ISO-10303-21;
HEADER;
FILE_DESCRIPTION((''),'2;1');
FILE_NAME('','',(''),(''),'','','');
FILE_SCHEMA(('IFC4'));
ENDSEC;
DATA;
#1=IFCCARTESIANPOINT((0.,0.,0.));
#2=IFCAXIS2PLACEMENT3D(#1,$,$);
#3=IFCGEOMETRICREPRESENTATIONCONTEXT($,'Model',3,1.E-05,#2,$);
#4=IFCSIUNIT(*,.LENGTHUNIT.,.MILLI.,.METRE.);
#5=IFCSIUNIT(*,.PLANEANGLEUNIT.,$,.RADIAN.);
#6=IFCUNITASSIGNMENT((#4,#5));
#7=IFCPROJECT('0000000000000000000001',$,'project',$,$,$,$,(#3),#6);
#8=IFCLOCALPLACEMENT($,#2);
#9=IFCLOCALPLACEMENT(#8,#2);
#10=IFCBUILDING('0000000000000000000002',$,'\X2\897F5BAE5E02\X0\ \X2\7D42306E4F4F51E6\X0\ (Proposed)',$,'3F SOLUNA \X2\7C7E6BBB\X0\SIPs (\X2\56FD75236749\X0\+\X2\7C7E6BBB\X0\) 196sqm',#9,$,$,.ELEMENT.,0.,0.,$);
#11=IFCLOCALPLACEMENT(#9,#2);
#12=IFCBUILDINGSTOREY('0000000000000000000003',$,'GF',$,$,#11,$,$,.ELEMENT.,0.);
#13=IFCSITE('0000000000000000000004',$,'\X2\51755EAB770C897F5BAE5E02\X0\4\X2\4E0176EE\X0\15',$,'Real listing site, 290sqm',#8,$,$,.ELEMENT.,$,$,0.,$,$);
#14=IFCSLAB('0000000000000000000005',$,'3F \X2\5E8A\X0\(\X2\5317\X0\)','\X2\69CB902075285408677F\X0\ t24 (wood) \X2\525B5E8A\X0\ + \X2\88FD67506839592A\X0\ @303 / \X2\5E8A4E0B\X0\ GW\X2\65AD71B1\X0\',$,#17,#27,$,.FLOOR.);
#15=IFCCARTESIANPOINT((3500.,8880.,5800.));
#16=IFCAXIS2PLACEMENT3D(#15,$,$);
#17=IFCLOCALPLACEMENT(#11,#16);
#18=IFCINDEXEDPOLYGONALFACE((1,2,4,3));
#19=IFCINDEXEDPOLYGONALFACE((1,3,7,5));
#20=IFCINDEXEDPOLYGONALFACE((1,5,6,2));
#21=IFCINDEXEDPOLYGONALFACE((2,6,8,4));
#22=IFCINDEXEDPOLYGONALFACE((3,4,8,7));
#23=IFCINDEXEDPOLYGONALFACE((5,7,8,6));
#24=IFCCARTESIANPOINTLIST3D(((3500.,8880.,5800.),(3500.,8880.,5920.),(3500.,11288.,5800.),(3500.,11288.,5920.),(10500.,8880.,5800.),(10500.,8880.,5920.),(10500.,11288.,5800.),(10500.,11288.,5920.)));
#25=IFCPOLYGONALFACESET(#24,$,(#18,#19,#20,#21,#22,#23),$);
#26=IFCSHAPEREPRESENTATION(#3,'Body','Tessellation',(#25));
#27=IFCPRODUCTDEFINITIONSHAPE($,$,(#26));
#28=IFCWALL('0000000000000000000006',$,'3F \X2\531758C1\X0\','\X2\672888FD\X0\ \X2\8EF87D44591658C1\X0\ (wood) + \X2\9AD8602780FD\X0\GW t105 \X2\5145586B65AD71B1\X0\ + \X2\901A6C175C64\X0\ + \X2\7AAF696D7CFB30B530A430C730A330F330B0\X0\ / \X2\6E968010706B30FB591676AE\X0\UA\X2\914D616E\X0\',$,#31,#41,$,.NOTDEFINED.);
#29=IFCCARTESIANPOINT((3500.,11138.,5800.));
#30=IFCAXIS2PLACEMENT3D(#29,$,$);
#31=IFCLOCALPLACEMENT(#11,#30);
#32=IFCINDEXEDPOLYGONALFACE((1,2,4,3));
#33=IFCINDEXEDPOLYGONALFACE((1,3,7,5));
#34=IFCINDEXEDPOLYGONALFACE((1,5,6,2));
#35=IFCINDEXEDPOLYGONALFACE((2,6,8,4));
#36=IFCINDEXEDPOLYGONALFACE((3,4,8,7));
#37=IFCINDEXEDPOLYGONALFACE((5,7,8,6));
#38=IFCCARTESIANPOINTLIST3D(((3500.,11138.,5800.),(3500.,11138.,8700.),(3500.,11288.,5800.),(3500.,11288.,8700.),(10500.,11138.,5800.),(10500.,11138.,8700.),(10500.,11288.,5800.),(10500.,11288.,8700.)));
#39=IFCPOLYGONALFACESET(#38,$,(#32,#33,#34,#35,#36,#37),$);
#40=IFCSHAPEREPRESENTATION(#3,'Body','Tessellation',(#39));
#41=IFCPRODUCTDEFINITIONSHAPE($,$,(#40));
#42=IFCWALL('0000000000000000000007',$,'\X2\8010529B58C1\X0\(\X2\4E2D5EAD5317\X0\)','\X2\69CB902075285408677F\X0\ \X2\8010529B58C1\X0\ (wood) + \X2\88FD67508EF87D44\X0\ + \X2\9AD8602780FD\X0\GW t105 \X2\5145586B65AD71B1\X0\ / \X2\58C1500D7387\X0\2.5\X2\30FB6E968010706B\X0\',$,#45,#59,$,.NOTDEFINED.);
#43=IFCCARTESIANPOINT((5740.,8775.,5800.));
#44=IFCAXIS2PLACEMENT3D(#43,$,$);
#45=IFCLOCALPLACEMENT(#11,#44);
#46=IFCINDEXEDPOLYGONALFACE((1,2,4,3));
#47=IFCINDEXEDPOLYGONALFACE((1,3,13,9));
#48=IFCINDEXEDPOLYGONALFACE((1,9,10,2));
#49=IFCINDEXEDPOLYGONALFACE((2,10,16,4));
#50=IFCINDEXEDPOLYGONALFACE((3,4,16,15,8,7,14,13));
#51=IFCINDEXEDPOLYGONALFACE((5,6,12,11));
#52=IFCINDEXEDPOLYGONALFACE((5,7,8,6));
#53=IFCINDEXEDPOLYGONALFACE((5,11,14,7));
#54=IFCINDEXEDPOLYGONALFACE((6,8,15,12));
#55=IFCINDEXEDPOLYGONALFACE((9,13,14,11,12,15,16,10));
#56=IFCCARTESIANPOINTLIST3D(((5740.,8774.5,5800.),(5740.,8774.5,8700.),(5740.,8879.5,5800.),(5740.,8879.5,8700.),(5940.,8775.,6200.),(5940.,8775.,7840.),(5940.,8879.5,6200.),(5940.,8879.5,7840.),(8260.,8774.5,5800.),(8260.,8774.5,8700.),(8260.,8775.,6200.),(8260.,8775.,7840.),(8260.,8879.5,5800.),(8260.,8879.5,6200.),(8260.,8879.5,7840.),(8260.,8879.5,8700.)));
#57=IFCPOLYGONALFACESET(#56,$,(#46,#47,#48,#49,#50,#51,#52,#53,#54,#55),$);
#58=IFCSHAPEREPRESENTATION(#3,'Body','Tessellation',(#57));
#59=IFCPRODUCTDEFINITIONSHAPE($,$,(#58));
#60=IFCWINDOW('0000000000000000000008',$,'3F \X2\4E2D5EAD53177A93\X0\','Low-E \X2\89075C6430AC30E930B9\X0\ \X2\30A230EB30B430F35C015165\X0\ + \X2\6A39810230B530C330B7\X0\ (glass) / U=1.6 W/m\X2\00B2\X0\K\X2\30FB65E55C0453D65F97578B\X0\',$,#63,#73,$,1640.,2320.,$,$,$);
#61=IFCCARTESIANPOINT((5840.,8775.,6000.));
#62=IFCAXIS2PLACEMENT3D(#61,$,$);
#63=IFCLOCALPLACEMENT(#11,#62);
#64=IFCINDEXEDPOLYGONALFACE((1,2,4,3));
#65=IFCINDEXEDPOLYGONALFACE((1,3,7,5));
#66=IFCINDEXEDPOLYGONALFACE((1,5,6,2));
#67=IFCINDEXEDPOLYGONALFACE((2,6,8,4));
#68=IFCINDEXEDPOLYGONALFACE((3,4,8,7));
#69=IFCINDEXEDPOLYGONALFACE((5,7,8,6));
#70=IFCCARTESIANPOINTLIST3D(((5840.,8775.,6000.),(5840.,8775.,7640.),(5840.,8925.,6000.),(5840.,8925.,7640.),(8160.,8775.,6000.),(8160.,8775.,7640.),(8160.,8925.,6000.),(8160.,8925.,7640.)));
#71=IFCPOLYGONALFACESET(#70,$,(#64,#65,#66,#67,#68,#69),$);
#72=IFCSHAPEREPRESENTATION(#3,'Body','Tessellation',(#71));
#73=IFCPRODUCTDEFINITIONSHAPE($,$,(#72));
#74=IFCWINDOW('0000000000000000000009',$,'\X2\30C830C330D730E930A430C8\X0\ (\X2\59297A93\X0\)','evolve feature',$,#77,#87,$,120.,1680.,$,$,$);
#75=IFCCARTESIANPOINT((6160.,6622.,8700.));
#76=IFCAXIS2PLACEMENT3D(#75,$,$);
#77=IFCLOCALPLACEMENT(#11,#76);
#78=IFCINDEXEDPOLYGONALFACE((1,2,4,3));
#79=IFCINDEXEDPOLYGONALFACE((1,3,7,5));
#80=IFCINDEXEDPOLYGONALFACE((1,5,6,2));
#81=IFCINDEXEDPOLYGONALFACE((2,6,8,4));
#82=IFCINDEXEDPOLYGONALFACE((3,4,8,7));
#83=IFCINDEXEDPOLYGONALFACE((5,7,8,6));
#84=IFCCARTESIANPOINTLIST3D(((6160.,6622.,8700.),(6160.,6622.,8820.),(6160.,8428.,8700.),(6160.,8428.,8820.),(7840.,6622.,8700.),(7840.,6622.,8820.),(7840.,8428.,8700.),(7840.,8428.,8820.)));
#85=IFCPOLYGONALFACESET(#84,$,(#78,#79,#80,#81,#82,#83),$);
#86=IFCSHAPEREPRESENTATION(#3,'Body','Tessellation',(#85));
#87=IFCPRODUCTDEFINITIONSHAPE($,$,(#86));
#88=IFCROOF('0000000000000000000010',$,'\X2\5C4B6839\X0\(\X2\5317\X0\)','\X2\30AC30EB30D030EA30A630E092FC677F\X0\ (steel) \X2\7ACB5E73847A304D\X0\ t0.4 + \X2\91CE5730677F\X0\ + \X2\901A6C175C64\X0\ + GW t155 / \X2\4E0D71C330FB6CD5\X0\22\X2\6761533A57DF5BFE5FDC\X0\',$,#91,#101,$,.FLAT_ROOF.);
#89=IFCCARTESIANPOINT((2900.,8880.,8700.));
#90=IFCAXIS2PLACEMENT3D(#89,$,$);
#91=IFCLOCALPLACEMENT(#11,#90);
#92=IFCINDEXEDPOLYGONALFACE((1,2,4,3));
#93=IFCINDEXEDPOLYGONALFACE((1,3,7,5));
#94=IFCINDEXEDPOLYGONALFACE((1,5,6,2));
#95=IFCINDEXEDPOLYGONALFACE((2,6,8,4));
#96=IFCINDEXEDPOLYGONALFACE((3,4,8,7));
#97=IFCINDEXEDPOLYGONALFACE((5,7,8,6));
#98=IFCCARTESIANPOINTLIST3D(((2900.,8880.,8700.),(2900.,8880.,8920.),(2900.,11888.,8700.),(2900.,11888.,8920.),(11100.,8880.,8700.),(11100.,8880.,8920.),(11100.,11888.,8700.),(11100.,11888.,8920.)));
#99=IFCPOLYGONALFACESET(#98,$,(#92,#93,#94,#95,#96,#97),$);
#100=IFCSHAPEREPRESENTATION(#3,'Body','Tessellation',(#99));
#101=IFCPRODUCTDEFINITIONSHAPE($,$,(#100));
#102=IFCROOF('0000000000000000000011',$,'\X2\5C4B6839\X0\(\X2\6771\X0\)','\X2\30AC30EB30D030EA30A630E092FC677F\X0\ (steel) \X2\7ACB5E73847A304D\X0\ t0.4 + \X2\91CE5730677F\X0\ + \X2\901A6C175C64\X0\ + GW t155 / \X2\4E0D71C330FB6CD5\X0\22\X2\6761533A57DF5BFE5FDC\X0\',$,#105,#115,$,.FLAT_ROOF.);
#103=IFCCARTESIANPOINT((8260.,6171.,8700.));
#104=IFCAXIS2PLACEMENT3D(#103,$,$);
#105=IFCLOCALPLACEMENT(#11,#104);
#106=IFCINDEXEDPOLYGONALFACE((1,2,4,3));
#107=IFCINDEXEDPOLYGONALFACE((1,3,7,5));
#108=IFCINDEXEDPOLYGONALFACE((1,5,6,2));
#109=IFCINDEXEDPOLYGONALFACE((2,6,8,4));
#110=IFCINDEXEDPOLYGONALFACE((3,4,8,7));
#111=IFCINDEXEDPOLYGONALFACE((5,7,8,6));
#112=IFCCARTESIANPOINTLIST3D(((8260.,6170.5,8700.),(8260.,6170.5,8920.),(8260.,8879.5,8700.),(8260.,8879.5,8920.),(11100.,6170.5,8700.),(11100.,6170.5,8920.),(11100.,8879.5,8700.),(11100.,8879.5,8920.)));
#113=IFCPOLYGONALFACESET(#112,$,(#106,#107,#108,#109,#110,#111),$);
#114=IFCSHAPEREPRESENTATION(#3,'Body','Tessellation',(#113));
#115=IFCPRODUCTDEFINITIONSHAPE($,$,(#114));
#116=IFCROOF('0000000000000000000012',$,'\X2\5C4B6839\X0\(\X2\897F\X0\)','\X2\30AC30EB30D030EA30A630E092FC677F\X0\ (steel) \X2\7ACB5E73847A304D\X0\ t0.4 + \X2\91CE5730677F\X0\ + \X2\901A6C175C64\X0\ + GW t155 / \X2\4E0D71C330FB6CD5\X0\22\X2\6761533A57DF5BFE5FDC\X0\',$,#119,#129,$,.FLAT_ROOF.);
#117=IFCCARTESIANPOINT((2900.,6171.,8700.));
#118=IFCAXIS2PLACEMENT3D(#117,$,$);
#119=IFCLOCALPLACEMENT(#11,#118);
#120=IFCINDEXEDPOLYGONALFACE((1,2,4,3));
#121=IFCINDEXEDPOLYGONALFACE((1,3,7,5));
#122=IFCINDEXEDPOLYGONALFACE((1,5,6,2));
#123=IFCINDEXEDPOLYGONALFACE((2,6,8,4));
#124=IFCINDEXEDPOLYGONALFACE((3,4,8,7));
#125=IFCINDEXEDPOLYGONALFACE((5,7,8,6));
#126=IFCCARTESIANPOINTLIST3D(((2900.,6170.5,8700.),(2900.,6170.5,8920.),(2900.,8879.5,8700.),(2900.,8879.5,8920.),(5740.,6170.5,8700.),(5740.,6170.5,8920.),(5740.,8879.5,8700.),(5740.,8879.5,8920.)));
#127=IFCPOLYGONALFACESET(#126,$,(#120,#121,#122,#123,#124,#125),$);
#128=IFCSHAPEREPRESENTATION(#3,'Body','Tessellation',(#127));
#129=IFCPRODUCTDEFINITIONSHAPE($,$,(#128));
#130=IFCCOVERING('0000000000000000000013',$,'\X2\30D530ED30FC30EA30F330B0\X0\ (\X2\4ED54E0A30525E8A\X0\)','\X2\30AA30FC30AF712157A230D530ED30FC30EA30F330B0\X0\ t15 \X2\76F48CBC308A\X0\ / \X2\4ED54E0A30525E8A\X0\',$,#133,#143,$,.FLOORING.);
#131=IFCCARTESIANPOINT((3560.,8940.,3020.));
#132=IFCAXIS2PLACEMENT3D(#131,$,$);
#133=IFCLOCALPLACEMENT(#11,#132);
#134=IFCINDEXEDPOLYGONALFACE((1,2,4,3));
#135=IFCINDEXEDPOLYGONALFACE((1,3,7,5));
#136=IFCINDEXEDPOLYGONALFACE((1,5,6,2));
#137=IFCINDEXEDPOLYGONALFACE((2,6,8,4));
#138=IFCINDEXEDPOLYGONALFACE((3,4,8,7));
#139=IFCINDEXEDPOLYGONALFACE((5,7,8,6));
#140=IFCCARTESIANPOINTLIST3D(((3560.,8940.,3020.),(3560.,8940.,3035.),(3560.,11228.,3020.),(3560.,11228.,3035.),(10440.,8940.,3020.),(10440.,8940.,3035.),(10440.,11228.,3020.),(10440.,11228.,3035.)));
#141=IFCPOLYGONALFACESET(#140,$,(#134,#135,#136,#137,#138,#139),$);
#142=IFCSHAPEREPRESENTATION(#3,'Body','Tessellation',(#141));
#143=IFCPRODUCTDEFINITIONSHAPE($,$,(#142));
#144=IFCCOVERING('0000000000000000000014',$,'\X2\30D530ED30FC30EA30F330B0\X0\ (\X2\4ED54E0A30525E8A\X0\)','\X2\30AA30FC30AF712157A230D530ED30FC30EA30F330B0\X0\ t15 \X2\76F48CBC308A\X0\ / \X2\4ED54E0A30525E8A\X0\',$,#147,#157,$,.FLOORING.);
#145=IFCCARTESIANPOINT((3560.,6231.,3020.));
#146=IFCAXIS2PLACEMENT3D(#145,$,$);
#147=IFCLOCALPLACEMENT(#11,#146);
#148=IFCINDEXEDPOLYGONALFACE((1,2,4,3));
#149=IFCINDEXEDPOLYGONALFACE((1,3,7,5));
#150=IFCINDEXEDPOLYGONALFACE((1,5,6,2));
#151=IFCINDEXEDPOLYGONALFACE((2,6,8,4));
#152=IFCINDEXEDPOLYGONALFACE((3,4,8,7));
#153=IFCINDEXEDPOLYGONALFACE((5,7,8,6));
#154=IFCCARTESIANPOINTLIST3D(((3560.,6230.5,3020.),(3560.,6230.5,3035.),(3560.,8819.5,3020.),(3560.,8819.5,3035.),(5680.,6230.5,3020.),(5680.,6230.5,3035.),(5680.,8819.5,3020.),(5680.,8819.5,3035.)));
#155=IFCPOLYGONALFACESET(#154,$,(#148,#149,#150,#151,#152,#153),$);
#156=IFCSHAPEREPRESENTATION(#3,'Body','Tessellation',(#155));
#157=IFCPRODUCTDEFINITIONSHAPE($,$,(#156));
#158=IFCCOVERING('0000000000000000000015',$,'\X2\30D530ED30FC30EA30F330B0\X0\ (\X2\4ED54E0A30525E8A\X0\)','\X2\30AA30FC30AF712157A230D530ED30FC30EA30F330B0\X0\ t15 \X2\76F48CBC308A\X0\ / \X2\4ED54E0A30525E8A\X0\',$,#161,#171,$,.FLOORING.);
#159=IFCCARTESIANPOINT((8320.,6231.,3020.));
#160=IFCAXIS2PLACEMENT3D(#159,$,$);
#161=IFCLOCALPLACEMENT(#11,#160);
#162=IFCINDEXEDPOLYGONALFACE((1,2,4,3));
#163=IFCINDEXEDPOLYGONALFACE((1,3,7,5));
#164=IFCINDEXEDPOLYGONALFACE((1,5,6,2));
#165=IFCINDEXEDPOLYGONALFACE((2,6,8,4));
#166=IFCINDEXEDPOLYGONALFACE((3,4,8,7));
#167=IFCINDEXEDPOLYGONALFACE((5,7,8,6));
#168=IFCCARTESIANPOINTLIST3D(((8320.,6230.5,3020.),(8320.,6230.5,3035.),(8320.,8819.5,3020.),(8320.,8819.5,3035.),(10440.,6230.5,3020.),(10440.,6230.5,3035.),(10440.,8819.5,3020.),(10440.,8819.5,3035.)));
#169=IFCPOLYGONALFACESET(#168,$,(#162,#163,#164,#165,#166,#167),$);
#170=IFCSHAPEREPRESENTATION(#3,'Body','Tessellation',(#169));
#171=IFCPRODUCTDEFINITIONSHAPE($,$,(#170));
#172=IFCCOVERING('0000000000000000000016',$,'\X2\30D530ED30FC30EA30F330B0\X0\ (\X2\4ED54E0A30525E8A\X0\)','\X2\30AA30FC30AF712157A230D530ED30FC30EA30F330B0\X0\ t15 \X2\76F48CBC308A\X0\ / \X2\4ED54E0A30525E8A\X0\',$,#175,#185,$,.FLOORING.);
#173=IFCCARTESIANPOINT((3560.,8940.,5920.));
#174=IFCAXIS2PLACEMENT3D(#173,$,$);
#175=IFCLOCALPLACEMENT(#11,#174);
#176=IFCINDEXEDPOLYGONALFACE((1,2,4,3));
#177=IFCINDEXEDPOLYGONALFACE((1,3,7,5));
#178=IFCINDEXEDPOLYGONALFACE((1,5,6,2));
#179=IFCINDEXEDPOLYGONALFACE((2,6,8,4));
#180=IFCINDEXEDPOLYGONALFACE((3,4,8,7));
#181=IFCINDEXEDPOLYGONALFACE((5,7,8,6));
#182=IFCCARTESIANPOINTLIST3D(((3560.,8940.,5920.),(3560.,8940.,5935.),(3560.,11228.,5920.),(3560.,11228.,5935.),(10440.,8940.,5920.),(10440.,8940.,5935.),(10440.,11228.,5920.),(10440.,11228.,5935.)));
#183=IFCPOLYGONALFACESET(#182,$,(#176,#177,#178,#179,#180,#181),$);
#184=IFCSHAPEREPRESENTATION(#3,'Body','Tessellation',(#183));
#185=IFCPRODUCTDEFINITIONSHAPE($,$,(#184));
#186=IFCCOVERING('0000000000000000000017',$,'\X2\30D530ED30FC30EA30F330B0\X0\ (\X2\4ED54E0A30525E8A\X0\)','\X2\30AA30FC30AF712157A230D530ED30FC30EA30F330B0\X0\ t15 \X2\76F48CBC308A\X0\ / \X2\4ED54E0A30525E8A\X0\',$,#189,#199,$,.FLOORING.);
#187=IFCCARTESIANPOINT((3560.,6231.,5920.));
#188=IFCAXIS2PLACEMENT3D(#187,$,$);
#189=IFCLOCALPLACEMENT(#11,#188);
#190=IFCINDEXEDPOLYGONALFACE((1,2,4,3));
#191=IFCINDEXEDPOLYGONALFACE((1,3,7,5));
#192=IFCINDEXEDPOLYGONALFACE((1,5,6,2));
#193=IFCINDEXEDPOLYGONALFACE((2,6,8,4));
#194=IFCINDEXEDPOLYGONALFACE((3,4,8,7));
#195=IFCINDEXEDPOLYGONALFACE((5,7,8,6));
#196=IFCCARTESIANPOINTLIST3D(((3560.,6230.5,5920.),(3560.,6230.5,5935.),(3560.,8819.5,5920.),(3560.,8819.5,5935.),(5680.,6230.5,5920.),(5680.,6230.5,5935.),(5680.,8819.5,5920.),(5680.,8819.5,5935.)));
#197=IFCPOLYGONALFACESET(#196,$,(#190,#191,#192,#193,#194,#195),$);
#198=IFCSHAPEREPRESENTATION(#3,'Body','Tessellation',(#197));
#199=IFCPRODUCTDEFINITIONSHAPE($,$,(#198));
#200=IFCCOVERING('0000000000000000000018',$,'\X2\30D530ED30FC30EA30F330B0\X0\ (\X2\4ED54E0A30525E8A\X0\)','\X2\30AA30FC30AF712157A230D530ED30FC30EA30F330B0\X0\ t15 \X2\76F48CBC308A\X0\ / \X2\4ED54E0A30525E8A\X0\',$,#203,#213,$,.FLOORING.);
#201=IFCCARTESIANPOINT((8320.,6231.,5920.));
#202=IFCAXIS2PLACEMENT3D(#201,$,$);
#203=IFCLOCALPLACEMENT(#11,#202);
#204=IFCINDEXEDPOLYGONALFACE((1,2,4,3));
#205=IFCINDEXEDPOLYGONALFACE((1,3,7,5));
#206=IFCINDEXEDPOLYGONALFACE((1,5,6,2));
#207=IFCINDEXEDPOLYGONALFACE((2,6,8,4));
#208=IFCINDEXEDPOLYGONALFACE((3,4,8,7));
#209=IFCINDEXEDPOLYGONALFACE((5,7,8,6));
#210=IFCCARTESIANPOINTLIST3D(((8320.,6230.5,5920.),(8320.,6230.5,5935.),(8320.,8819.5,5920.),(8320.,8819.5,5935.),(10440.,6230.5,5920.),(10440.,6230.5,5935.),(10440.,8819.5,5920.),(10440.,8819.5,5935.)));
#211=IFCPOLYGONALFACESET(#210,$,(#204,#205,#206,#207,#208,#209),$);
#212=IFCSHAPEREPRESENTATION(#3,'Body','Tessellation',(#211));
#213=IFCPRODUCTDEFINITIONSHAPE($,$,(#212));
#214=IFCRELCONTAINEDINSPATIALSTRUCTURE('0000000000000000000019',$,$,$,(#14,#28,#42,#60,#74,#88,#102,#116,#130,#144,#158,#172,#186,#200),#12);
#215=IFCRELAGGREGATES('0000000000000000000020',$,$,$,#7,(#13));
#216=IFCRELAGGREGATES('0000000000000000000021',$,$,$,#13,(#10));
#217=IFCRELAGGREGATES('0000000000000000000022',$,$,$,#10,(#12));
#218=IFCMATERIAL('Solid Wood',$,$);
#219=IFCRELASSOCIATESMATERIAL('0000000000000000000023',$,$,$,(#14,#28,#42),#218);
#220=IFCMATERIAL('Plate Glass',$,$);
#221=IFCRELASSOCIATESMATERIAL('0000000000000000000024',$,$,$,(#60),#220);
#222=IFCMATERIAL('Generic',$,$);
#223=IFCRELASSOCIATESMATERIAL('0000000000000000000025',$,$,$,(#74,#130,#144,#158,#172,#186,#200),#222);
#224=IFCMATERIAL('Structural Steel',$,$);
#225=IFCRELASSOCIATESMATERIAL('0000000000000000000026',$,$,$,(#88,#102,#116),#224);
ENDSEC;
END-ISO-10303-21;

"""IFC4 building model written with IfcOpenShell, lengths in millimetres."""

from ifc_helpers import new_model, si_unit, frame, frame_2d, origin, place, context, project, spatial, rectangle, extrude, material, element, fill, save


model = new_model("IFC4")

# Units and contexts
model_context = context("Model", 3, precision=1e-05, world=origin())
ifc_project = project(units=[si_unit("LENGTHUNIT", "METRE", prefix="MILLI"), si_unit("PLANEANGLEUNIT", "RADIAN")], contexts=[model_context])

# Site, building, storey
site_placement = place(None, origin())
site = spatial("IfcSite", under=ifc_project, at=site_placement, Name="兵庫県西宮市4丁目15", ObjectType="Real listing site, 290sqm", CompositionType="ELEMENT", RefElevation=0.0)
building_placement = place(site_placement, origin())
building = spatial("IfcBuilding", under=site, at=building_placement, Name="西宮市 終の住処 (Proposed)", ObjectType="3F SOLUNA 籾殻SIPs (国産杉+籾殻) 196sqm", CompositionType="ELEMENT", ElevationOfRefHeight=0.0, ElevationOfTerrain=0.0)
storey_placement = place(building_placement, origin())
storey = spatial("IfcBuildingStorey", under=building, at=storey_placement, Name="GF", CompositionType="ELEMENT", Elevation=0.0)

# Slab
ifc_material_1 = material(Name="Solid Wood")
slab_placement = place(storey_placement, frame((3500.0, 8880.0, 5800.0)))
element("IfcSlab", 1, at=slab_placement, inside=storey, material=ifc_material_1, Name="3F 床(北)", Description="構造用合板 t24 (wood) 剛床 + 製材根太 @303 / 床下 GW断熱", PredefinedType="FLOOR", context=model_context, shape_type="SweptSolid", body=[
    extrude(rectangle(XDim=7000.0, YDim=2408.0, at=frame_2d((3500.0, 1204.0))), frame((3500.0, 8880.0, 5800.0)), (0.0, 0.0, 1.0), 120.0),
])

# Wall
wall_1_placement = place(storey_placement, frame((3500.0, 11138.0, 5800.0)))
element("IfcWall", 2, at=wall_1_placement, inside=storey, material=ifc_material_1, Name="3F 北壁", Description="木製 軸組外壁 (wood) + 高性能GW t105 充填断熱 + 通気層 + 窯業系サイディング / 準耐火・外皮UA配慮", PredefinedType="NOTDEFINED", context=model_context, shape_type="SweptSolid", body=[
    extrude(rectangle(XDim=7000.0, YDim=150.0, at=frame_2d((3500.0, 75.0))), frame((3500.0, 11138.0, 5800.0)), (0.0, 0.0, 1.0), 2900.0),
])

# Wall, opening, window
wall_2_placement = place(storey_placement, frame((5740.0, 8775.0, 5800.0)))
wall_2 = element("IfcWall", 3, at=wall_2_placement, inside=storey, material=ifc_material_1, Name="耐力壁(中庭北)", Description="構造用合板 耐力壁 (wood) + 製材軸組 + 高性能GW t105 充填断熱 / 壁倍率2.5・準耐火", PredefinedType="NOTDEFINED", context=model_context, shape_type="SweptSolid", body=[
    extrude(rectangle(XDim=2520.0, YDim=105.0, at=frame_2d((1260.0, 52.0))), frame((5740.0, 8775.0, 5800.0)), (0.0, 0.0, 1.0), 2900.0),
])
opening_placement = place(storey_placement, frame((5840.0, 8775.0, 6000.0)))
opening = element("IfcOpeningElement", 4, at=opening_placement, cuts=wall_2, PredefinedType="NOTDEFINED", context=model_context, shape_type="SweptSolid", body=[
    extrude(rectangle(XDim=2320.0, YDim=150.0, at=frame_2d((1160.0, 75.0))), frame((5840.0, 8775.0, 6000.0)), (0.0, 0.0, 1.0), 1640.0),
])
ifc_material_2 = material(Name="Plate Glass")
window_1_placement = place(storey_placement, frame((5840.0, 8775.0, 6000.0)))
window_1 = element("IfcWindow", 5, at=window_1_placement, inside=storey, material=ifc_material_2, Name="3F 中庭北窓", Description="Low-E 複層ガラス アルゴン封入 + 樹脂サッシ (glass) / U=1.6 W/m²K・日射取得型", OverallHeight=1640.0, OverallWidth=2320.0, context=model_context, shape_type="SweptSolid", body=[
    extrude(rectangle(XDim=2320.0, YDim=150.0, at=frame_2d((1160.0, 75.0))), frame((5840.0, 8775.0, 6000.0)), (0.0, 0.0, 1.0), 1640.0),
])
fill(opening, window_1)

# Window
ifc_material_3 = material(Name="Generic")
window_2_placement = place(storey_placement, frame((6160.0, 6622.0, 8700.0)))
element("IfcWindow", 6, at=window_2_placement, inside=storey, material=ifc_material_3, Name="トップライト (天窓)", Description="evolve feature", OverallHeight=120.0, OverallWidth=1680.0, context=model_context, shape_type="SweptSolid", body=[
    extrude(rectangle(XDim=1680.0, YDim=1806.0, at=frame_2d((840.0, 903.0))), frame((6160.0, 6622.0, 8700.0)), (0.0, 0.0, 1.0), 120.0),
])

# Roofs
ifc_material_4 = material(Name="Structural Steel")
roof_1_placement = place(storey_placement, frame((2900.0, 8880.0, 8700.0)))
element("IfcRoof", 7, at=roof_1_placement, inside=storey, material=ifc_material_4, Name="屋根(北)", Description="ガルバリウム鋼板 (steel) 立平葺き t0.4 + 野地板 + 通気層 + GW t155 / 不燃・法22条区域対応", PredefinedType="FLAT_ROOF", context=model_context, shape_type="SweptSolid", body=[
    extrude(rectangle(XDim=8200.0, YDim=3008.0, at=frame_2d((4100.0, 1504.0))), frame((2900.0, 8880.0, 8700.0)), (0.0, 0.0, 1.0), 220.0),
])
roof_2_placement = place(storey_placement, frame((8260.0, 6171.0, 8700.0)))
element("IfcRoof", 8, at=roof_2_placement, inside=storey, material=ifc_material_4, Name="屋根(東)", Description="ガルバリウム鋼板 (steel) 立平葺き t0.4 + 野地板 + 通気層 + GW t155 / 不燃・法22条区域対応", PredefinedType="FLAT_ROOF", context=model_context, shape_type="SweptSolid", body=[
    extrude(rectangle(XDim=2840.0, YDim=2709.0, at=frame_2d((1420.0, 1354.0))), frame((8260.0, 6171.0, 8700.0)), (0.0, 0.0, 1.0), 220.0),
])
roof_3_placement = place(storey_placement, frame((2900.0, 6171.0, 8700.0)))
element("IfcRoof", 9, at=roof_3_placement, inside=storey, material=ifc_material_4, Name="屋根(西)", Description="ガルバリウム鋼板 (steel) 立平葺き t0.4 + 野地板 + 通気層 + GW t155 / 不燃・法22条区域対応", PredefinedType="FLAT_ROOF", context=model_context, shape_type="SweptSolid", body=[
    extrude(rectangle(XDim=2840.0, YDim=2709.0, at=frame_2d((1420.0, 1354.0))), frame((2900.0, 6171.0, 8700.0)), (0.0, 0.0, 1.0), 220.0),
])

# Coverings
covering_1_placement = place(storey_placement, frame((3560.0, 8940.0, 3020.0)))
element("IfcCovering", 10, at=covering_1_placement, inside=storey, material=ifc_material_3, Name="フローリング (仕上げ床)", Description="オーク無垢フローリング t15 直貼り / 仕上げ床", PredefinedType="FLOORING", context=model_context, shape_type="SweptSolid", body=[
    extrude(rectangle(XDim=6880.0, YDim=2288.0, at=frame_2d((3440.0, 1144.0))), frame((3560.0, 8940.0, 3020.0)), (0.0, 0.0, 1.0), 15.0),
])
covering_2_placement = place(storey_placement, frame((3560.0, 6231.0, 3020.0)))
element("IfcCovering", 11, at=covering_2_placement, inside=storey, material=ifc_material_3, Name="フローリング (仕上げ床)", Description="オーク無垢フローリング t15 直貼り / 仕上げ床", PredefinedType="FLOORING", context=model_context, shape_type="SweptSolid", body=[
    extrude(rectangle(XDim=2120.0, YDim=2589.0, at=frame_2d((1060.0, 1294.0))), frame((3560.0, 6231.0, 3020.0)), (0.0, 0.0, 1.0), 15.0),
])
covering_3_placement = place(storey_placement, frame((8320.0, 6231.0, 3020.0)))
element("IfcCovering", 12, at=covering_3_placement, inside=storey, material=ifc_material_3, Name="フローリング (仕上げ床)", Description="オーク無垢フローリング t15 直貼り / 仕上げ床", PredefinedType="FLOORING", context=model_context, shape_type="SweptSolid", body=[
    extrude(rectangle(XDim=2120.0, YDim=2589.0, at=frame_2d((1060.0, 1294.0))), frame((8320.0, 6231.0, 3020.0)), (0.0, 0.0, 1.0), 15.0),
])
covering_4_placement = place(storey_placement, frame((3560.0, 8940.0, 5920.0)))
element("IfcCovering", 13, at=covering_4_placement, inside=storey, material=ifc_material_3, Name="フローリング (仕上げ床)", Description="オーク無垢フローリング t15 直貼り / 仕上げ床", PredefinedType="FLOORING", context=model_context, shape_type="SweptSolid", body=[
    extrude(rectangle(XDim=6880.0, YDim=2288.0, at=frame_2d((3440.0, 1144.0))), frame((3560.0, 8940.0, 5920.0)), (0.0, 0.0, 1.0), 15.0),
])
covering_5_placement = place(storey_placement, frame((3560.0, 6231.0, 5920.0)))
element("IfcCovering", 14, at=covering_5_placement, inside=storey, material=ifc_material_3, Name="フローリング (仕上げ床)", Description="オーク無垢フローリング t15 直貼り / 仕上げ床", PredefinedType="FLOORING", context=model_context, shape_type="SweptSolid", body=[
    extrude(rectangle(XDim=2120.0, YDim=2589.0, at=frame_2d((1060.0, 1294.0))), frame((3560.0, 6231.0, 5920.0)), (0.0, 0.0, 1.0), 15.0),
])
covering_6_placement = place(storey_placement, frame((8320.0, 6231.0, 5920.0)))
element("IfcCovering", 15, at=covering_6_placement, inside=storey, material=ifc_material_3, Name="フローリング (仕上げ床)", Description="オーク無垢フローリング t15 直貼り / 仕上げ床", PredefinedType="FLOORING", context=model_context, shape_type="SweptSolid", body=[
    extrude(rectangle(XDim=2120.0, YDim=2589.0, at=frame_2d((1060.0, 1294.0))), frame((8320.0, 6231.0, 5920.0)), (0.0, 0.0, 1.0), 15.0),
])

save(model, "model.ifc")
